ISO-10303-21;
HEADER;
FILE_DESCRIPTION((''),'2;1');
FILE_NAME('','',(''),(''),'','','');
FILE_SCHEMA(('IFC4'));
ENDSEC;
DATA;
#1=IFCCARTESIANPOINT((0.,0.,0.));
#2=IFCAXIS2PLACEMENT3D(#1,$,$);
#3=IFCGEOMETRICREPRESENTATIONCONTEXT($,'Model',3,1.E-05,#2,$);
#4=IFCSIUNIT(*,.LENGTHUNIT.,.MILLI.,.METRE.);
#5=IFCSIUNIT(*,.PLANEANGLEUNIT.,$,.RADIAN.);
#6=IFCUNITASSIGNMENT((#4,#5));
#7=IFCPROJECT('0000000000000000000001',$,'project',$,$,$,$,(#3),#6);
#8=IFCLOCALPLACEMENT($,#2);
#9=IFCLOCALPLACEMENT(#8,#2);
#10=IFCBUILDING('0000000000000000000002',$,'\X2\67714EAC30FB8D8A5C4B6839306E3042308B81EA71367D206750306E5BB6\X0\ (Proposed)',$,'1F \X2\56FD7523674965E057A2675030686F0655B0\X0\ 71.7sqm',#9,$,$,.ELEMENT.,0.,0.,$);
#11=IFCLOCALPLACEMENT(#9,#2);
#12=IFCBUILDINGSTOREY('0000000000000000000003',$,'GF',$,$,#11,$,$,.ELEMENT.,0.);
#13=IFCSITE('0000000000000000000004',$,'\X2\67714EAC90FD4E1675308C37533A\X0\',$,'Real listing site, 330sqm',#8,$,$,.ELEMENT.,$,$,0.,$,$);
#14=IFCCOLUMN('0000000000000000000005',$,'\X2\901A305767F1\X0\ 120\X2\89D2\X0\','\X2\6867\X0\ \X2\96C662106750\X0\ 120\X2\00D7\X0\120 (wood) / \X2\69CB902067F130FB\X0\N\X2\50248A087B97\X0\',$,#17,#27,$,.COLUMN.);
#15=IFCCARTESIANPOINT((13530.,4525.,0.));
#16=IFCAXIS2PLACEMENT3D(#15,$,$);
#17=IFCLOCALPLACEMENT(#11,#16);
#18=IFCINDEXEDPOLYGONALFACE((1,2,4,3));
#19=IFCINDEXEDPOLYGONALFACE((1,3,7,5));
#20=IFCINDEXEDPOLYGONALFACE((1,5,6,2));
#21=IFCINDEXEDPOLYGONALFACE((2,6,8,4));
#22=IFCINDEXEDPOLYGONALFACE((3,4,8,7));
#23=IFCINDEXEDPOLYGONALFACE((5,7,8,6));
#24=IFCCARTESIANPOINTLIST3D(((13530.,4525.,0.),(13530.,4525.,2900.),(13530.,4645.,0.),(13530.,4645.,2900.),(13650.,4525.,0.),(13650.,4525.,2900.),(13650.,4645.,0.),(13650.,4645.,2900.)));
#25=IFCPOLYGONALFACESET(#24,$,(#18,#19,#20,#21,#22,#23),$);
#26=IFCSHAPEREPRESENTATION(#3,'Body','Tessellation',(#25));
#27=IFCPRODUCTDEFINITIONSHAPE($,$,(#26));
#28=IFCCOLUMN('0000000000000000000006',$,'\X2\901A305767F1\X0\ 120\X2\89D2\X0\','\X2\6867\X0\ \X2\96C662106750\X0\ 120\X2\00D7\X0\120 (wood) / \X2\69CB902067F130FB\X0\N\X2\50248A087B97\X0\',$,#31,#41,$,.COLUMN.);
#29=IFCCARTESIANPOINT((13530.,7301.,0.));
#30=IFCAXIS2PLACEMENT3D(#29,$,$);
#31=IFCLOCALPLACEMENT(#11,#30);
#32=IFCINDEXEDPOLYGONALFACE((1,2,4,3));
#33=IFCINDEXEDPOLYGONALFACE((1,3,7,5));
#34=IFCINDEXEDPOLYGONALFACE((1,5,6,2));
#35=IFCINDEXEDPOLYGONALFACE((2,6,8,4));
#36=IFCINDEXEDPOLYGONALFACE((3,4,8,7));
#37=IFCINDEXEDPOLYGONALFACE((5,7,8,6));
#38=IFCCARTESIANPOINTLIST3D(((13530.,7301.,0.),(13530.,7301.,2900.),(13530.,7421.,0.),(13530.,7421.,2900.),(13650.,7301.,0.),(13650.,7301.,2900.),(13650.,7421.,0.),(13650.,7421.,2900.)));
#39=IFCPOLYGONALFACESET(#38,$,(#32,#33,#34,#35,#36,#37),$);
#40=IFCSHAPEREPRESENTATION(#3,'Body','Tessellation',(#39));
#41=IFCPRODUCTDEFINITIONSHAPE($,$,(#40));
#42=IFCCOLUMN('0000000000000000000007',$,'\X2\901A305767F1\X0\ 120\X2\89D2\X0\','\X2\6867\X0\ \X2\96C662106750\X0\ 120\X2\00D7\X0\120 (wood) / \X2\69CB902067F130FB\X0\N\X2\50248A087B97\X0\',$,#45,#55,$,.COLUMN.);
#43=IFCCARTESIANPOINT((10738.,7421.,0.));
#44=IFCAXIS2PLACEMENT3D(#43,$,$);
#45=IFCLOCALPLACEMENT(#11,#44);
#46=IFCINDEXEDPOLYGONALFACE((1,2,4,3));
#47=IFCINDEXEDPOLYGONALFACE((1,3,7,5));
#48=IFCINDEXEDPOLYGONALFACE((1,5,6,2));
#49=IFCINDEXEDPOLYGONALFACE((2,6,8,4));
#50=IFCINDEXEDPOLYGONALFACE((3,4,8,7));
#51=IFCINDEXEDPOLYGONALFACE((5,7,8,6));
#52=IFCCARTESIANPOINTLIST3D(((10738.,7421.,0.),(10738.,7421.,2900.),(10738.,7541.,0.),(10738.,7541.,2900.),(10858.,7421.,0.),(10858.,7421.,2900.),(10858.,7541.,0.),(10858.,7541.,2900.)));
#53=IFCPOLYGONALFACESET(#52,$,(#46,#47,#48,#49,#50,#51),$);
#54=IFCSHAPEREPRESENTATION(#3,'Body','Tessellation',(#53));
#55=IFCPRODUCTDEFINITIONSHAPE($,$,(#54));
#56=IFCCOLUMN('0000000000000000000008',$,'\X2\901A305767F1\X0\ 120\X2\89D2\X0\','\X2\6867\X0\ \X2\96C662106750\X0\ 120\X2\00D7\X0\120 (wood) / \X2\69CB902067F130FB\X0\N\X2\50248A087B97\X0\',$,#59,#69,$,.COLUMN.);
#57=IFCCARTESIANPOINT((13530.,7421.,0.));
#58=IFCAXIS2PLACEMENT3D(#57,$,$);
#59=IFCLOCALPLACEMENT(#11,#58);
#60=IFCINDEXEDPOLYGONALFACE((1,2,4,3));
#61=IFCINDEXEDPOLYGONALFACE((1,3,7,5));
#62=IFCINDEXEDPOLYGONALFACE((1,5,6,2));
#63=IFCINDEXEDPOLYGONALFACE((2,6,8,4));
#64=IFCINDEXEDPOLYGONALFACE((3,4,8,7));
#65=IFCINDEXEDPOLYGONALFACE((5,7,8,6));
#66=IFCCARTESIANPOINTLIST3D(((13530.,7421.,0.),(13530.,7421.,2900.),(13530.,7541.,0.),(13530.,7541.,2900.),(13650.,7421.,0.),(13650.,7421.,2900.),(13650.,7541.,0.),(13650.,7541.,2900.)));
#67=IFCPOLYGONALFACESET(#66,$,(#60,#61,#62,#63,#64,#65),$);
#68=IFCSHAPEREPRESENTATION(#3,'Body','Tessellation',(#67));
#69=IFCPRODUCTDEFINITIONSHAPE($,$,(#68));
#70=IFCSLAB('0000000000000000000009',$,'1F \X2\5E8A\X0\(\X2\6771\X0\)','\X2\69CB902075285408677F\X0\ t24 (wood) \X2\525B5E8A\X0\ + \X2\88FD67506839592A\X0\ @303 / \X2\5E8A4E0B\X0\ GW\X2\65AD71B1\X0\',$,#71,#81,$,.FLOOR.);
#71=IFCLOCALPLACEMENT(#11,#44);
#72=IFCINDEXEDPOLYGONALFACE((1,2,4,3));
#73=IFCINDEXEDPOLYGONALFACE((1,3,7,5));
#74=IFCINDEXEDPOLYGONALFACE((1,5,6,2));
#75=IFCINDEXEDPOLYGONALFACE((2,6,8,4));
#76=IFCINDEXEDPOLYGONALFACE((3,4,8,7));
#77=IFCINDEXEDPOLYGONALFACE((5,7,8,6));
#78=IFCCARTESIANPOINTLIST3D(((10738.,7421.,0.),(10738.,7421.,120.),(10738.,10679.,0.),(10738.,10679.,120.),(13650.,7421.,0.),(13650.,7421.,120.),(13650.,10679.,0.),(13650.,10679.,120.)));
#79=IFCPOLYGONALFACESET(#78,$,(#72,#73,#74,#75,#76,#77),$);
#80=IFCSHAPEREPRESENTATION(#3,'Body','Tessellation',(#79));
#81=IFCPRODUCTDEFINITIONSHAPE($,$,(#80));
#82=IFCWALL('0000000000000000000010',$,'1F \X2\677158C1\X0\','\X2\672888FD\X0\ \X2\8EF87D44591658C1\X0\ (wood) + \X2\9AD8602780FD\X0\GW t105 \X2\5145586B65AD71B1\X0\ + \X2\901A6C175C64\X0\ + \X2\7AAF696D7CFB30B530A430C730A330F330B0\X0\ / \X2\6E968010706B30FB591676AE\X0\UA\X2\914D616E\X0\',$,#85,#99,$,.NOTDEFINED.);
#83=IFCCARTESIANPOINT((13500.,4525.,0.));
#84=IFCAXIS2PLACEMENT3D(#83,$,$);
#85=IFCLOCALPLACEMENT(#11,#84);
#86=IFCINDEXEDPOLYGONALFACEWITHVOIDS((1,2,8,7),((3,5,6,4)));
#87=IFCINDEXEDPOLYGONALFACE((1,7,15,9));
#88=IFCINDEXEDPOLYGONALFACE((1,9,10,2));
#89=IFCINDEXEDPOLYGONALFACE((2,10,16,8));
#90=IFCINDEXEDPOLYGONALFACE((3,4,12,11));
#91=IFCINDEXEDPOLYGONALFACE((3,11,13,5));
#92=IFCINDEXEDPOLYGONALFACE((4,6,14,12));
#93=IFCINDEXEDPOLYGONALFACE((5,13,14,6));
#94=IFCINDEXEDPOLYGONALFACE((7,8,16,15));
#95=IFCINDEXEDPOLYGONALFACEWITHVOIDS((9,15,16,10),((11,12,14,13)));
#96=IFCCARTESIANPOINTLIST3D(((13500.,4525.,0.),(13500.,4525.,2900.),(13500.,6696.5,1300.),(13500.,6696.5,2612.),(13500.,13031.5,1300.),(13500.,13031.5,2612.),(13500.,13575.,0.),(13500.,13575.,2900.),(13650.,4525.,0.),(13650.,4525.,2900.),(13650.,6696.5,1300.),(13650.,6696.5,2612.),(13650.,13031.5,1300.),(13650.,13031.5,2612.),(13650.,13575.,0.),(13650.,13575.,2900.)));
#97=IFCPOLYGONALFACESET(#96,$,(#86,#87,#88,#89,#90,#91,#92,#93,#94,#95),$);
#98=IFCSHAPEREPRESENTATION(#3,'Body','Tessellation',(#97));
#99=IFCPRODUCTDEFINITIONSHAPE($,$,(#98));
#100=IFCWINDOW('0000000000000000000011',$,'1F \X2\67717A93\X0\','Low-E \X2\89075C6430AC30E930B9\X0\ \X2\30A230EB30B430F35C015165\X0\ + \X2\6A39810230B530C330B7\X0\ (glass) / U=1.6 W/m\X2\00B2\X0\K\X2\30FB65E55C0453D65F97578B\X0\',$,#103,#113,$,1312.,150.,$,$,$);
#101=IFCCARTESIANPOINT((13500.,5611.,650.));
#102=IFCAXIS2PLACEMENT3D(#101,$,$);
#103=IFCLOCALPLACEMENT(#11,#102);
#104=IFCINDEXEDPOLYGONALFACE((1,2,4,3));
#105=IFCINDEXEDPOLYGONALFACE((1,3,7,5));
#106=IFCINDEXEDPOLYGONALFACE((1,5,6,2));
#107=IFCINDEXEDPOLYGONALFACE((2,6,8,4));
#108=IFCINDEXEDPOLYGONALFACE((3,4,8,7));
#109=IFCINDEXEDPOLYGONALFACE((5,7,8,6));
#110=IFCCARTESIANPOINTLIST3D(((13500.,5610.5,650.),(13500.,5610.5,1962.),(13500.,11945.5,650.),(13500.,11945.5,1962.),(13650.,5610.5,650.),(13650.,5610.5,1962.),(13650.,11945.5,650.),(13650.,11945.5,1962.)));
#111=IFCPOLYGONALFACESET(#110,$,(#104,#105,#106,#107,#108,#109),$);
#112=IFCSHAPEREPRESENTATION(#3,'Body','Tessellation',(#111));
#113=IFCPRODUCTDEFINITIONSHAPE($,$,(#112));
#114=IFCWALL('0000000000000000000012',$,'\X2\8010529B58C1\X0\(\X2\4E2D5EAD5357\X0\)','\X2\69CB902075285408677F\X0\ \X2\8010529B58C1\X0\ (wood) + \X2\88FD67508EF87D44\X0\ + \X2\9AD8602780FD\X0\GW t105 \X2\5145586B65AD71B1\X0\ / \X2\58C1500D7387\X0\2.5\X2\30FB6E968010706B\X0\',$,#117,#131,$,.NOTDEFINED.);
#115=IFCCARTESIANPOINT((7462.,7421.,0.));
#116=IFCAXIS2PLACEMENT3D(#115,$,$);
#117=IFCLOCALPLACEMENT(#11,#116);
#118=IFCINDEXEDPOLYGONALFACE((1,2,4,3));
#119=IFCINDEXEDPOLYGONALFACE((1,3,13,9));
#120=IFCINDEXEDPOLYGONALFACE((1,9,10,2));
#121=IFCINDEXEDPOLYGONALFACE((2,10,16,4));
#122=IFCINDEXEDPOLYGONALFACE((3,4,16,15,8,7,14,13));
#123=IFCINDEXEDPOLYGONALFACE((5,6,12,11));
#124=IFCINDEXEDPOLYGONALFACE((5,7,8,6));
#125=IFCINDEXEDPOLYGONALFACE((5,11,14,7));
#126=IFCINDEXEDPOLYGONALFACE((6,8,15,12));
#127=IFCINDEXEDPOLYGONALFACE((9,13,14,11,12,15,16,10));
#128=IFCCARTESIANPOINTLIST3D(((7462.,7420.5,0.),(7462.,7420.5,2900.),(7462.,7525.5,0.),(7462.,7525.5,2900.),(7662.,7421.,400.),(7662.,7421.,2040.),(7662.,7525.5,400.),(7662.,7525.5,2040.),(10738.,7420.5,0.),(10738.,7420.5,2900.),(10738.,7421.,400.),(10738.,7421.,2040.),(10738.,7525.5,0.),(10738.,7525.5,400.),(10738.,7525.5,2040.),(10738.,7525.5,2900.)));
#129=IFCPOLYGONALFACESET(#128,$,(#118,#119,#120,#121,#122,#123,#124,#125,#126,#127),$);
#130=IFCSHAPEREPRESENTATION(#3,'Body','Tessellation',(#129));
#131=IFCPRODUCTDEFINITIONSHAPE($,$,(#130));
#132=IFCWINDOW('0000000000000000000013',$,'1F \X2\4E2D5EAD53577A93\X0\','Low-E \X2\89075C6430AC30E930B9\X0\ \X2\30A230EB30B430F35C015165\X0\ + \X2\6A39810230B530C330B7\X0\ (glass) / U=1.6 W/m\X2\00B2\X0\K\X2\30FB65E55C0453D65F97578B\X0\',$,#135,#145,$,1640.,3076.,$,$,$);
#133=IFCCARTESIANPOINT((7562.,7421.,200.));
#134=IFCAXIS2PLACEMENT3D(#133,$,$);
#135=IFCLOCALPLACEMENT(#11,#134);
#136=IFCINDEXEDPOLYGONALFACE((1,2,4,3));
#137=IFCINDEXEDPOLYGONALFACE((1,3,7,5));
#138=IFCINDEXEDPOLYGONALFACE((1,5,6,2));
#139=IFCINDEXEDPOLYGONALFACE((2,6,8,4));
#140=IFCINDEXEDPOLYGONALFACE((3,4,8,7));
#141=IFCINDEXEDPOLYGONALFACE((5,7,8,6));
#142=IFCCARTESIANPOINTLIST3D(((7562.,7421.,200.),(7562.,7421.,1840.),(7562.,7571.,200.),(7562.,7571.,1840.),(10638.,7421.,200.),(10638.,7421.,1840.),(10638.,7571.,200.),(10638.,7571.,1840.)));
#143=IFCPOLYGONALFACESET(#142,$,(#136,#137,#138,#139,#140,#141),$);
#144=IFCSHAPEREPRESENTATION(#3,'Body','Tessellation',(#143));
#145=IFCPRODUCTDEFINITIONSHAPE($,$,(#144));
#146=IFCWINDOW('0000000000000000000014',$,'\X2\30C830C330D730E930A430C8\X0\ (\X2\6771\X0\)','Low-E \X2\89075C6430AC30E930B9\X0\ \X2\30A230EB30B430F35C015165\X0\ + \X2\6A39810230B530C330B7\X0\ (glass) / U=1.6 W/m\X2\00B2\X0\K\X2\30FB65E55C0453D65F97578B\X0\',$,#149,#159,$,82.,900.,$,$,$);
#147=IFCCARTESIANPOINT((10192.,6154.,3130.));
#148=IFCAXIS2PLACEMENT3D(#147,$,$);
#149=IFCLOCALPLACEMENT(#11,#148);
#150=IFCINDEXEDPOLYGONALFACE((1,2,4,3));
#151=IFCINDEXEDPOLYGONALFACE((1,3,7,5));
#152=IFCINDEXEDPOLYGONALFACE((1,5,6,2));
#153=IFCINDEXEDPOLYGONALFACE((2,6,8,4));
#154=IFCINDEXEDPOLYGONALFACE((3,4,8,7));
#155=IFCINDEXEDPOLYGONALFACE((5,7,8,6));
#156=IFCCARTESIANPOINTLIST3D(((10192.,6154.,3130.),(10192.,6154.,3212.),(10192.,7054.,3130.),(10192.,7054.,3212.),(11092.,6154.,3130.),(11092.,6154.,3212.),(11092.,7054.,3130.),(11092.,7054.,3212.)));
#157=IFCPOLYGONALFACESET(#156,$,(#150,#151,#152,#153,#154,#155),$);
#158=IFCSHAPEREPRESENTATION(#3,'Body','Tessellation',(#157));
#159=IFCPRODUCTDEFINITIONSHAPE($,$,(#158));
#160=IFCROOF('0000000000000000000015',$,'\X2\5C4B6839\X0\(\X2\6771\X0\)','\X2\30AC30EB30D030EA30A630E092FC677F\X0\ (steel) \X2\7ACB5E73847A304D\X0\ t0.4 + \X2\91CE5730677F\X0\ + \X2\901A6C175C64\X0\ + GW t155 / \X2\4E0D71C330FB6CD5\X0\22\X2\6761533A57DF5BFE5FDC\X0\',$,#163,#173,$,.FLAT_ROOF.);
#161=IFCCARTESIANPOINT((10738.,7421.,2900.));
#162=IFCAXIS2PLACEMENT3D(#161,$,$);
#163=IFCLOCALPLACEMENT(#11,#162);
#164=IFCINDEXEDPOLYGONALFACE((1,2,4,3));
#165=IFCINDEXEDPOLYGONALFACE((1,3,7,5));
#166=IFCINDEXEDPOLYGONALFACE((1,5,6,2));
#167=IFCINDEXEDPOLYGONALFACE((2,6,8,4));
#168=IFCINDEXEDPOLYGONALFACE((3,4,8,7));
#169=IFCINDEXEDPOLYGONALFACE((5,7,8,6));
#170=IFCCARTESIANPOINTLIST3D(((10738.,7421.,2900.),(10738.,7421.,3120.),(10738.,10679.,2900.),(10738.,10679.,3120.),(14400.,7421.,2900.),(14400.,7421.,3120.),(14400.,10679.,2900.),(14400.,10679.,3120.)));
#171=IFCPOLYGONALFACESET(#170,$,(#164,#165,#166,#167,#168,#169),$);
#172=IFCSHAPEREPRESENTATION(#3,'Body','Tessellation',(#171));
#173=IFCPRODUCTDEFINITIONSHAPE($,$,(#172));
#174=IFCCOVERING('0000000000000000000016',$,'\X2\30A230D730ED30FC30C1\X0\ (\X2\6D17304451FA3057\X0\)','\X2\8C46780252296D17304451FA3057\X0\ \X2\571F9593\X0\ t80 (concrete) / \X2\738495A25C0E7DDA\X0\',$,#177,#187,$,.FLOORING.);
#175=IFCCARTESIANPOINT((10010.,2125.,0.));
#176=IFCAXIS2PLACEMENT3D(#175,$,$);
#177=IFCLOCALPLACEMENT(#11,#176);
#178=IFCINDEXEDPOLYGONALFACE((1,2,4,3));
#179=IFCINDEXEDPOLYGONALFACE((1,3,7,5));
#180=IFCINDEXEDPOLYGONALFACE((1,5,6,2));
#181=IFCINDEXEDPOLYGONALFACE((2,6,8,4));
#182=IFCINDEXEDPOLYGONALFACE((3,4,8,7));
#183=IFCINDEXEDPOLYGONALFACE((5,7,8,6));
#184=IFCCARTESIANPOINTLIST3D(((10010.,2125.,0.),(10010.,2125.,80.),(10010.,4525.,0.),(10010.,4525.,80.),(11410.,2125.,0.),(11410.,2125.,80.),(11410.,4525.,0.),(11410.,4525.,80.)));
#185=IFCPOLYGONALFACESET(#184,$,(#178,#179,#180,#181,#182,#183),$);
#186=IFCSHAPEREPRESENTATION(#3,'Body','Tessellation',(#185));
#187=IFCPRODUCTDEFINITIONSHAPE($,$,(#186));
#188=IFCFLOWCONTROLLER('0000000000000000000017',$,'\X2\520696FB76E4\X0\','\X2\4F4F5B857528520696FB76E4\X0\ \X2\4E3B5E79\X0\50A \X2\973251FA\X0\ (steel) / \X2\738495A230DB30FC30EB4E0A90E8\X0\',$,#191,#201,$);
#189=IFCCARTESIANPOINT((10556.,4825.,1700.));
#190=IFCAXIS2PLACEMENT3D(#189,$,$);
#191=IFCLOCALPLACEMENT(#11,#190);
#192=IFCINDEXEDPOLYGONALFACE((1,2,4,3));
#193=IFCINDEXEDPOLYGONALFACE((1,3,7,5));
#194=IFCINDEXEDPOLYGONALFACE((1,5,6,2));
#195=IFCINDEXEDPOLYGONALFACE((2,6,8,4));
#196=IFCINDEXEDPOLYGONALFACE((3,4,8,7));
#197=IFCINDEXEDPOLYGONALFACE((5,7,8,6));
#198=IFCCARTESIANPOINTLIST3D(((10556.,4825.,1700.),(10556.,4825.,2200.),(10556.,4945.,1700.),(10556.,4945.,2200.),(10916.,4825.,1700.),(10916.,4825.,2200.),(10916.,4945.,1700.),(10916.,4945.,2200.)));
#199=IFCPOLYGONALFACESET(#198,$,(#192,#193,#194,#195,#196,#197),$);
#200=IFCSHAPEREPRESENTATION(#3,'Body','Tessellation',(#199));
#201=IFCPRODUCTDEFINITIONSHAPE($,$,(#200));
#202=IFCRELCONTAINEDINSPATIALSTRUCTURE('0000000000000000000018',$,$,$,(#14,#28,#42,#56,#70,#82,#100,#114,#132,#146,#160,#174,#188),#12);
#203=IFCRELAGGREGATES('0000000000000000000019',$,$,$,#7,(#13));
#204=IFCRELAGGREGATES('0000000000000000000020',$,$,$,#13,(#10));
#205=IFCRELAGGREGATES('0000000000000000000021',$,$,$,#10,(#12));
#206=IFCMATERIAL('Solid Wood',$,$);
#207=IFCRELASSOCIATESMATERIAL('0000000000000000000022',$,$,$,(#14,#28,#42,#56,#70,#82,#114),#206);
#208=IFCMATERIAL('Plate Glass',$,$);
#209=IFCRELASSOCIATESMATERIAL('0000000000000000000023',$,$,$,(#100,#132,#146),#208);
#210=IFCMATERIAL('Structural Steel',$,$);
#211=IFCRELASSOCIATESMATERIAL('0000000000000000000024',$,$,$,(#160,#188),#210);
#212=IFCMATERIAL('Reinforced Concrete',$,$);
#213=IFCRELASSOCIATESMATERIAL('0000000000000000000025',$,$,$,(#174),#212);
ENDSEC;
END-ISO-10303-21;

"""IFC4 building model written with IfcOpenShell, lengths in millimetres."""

from ifc_helpers import new_model, si_unit, frame, frame_2d, origin, place, context, project, spatial, rectangle, extrude, material, element, fill, save


model = new_model("IFC4")

# Units and contexts
model_context = context("Model", 3, precision=1e-05, world=origin())
ifc_project = project(units=[si_unit("LENGTHUNIT", "METRE", prefix="MILLI"), si_unit("PLANEANGLEUNIT", "RADIAN")], contexts=[model_context])

# Site, building, storey
site_placement = place(None, origin())
site = spatial("IfcSite", under=ifc_project, at=site_placement, Name="東京都世田谷区", ObjectType="Real listing site, 330sqm", CompositionType="ELEMENT", RefElevation=0.0)
building_placement = place(site_placement, origin())
building = spatial("IfcBuilding", under=site, at=building_placement, Name="東京・越屋根のある自然素材の家 (Proposed)", ObjectType="1F 国産杉无垢材と漆喰 71.7sqm", CompositionType="ELEMENT", ElevationOfRefHeight=0.0, ElevationOfTerrain=0.0)
storey_placement = place(building_placement, origin())
storey = spatial("IfcBuildingStorey", under=building, at=storey_placement, Name="GF", CompositionType="ELEMENT", Elevation=0.0)

# Columns
ifc_material_1 = material(Name="Solid Wood")
column_1_placement = place(storey_placement, frame((13530.0, 4525.0, 0.0)))
element("IfcColumn", 1, at=column_1_placement, inside=storey, material=ifc_material_1, Name="通し柱 120角", Description="桧 集成材 120×120 (wood) / 構造柱・N値計算", PredefinedType="COLUMN", context=model_context, shape_type="SweptSolid", body=[
    extrude(rectangle(XDim=120.0, YDim=120.0, at=frame_2d((60.0, 60.0))), frame((13530.0, 4525.0, 0.0)), (0.0, 0.0, 1.0), 2900.0),
])
column_2_placement = place(storey_placement, frame((13530.0, 7301.0, 0.0)))
element("IfcColumn", 2, at=column_2_placement, inside=storey, material=ifc_material_1, Name="通し柱 120角", Description="桧 集成材 120×120 (wood) / 構造柱・N値計算", PredefinedType="COLUMN", context=model_context, shape_type="SweptSolid", body=[
    extrude(rectangle(XDim=120.0, YDim=120.0, at=frame_2d((60.0, 60.0))), frame((13530.0, 7301.0, 0.0)), (0.0, 0.0, 1.0), 2900.0),
])
column_3_placement = place(storey_placement, frame((10738.0, 7421.0, 0.0)))
element("IfcColumn", 3, at=column_3_placement, inside=storey, material=ifc_material_1, Name="通し柱 120角", Description="桧 集成材 120×120 (wood) / 構造柱・N値計算", PredefinedType="COLUMN", context=model_context, shape_type="SweptSolid", body=[
    extrude(rectangle(XDim=120.0, YDim=120.0, at=frame_2d((60.0, 60.0))), frame((10738.0, 7421.0, 0.0)), (0.0, 0.0, 1.0), 2900.0),
])
column_4_placement = place(storey_placement, frame((13530.0, 7421.0, 0.0)))
element("IfcColumn", 4, at=column_4_placement, inside=storey, material=ifc_material_1, Name="通し柱 120角", Description="桧 集成材 120×120 (wood) / 構造柱・N値計算", PredefinedType="COLUMN", context=model_context, shape_type="SweptSolid", body=[
    extrude(rectangle(XDim=120.0, YDim=120.0, at=frame_2d((60.0, 60.0))), frame((13530.0, 7421.0, 0.0)), (0.0, 0.0, 1.0), 2900.0),
])

# Slab
slab_placement = place(storey_placement, frame((10738.0, 7421.0, 0.0)))
element("IfcSlab", 5, at=slab_placement, inside=storey, material=ifc_material_1, Name="1F 床(東)", Description="構造用合板 t24 (wood) 剛床 + 製材根太 @303 / 床下 GW断熱", PredefinedType="FLOOR", context=model_context, shape_type="SweptSolid", body=[
    extrude(rectangle(XDim=2912.0, YDim=3258.0, at=frame_2d((1456.0, 1629.0))), frame((10738.0, 7421.0, 0.0)), (0.0, 0.0, 1.0), 120.0),
])

# Walls, openings, windows
wall_1_placement = place(storey_placement, frame((13500.0, 4525.0, 0.0)))
wall_1 = element("IfcWall", 6, at=wall_1_placement, inside=storey, material=ifc_material_1, Name="1F 東壁", Description="木製 軸組外壁 (wood) + 高性能GW t105 充填断熱 + 通気層 + 窯業系サイディング / 準耐火・外皮UA配慮", PredefinedType="NOTDEFINED", context=model_context, shape_type="SweptSolid", body=[
    extrude(rectangle(XDim=150.0, YDim=9050.0, at=frame_2d((75.0, 4525.0))), frame((13500.0, 4525.0, 0.0)), (0.0, 0.0, 1.0), 2900.0),
])
opening_1_placement = place(storey_placement, frame((13500.0, 5611.0, 650.0)))
opening_1 = element("IfcOpeningElement", 7, at=opening_1_placement, cuts=wall_1, PredefinedType="NOTDEFINED", context=model_context, shape_type="SweptSolid", body=[
    extrude(rectangle(XDim=150.0, YDim=6335.0, at=frame_2d((75.0, 3167.0))), frame((13500.0, 5611.0, 650.0)), (0.0, 0.0, 1.0), 1312.0),
])
ifc_material_2 = material(Name="Plate Glass")
window_1_placement = place(storey_placement, frame((13500.0, 5611.0, 650.0)))
window_1 = element("IfcWindow", 8, at=window_1_placement, inside=storey, material=ifc_material_2, Name="1F 東窓", Description="Low-E 複層ガラス アルゴン封入 + 樹脂サッシ (glass) / U=1.6 W/m²K・日射取得型", OverallHeight=1312.0, OverallWidth=150.0, context=model_context, shape_type="SweptSolid", body=[
    extrude(rectangle(XDim=150.0, YDim=6335.0, at=frame_2d((75.0, 3167.0))), frame((13500.0, 5611.0, 650.0)), (0.0, 0.0, 1.0), 1312.0),
])
fill(opening_1, window_1)
wall_2_placement = place(storey_placement, frame((7462.0, 7421.0, 0.0)))
wall_2 = element("IfcWall", 9, at=wall_2_placement, inside=storey, material=ifc_material_1, Name="耐力壁(中庭南)", Description="構造用合板 耐力壁 (wood) + 製材軸組 + 高性能GW t105 充填断熱 / 壁倍率2.5・準耐火", PredefinedType="NOTDEFINED", context=model_context, shape_type="SweptSolid", body=[
    extrude(rectangle(XDim=3276.0, YDim=105.0, at=frame_2d((1638.0, 52.0))), frame((7462.0, 7421.0, 0.0)), (0.0, 0.0, 1.0), 2900.0),
])
opening_2_placement = place(storey_placement, frame((7562.0, 7421.0, 200.0)))
opening_2 = element("IfcOpeningElement", 10, at=opening_2_placement, cuts=wall_2, PredefinedType="NOTDEFINED", context=model_context, shape_type="SweptSolid", body=[
    extrude(rectangle(XDim=3076.0, YDim=150.0, at=frame_2d((1538.0, 75.0))), frame((7562.0, 7421.0, 200.0)), (0.0, 0.0, 1.0), 1640.0),
])
window_2_placement = place(storey_placement, frame((7562.0, 7421.0, 200.0)))
window_2 = element("IfcWindow", 11, at=window_2_placement, inside=storey, material=ifc_material_2, Name="1F 中庭南窓", Description="Low-E 複層ガラス アルゴン封入 + 樹脂サッシ (glass) / U=1.6 W/m²K・日射取得型", OverallHeight=1640.0, OverallWidth=3076.0, context=model_context, shape_type="SweptSolid", body=[
    extrude(rectangle(XDim=3076.0, YDim=150.0, at=frame_2d((1538.0, 75.0))), frame((7562.0, 7421.0, 200.0)), (0.0, 0.0, 1.0), 1640.0),
])
fill(opening_2, window_2)

# Window
window_3_placement = place(storey_placement, frame((10192.0, 6154.0, 3130.0)))
element("IfcWindow", 12, at=window_3_placement, inside=storey, material=ifc_material_2, Name="トップライト (東)", Description="Low-E 複層ガラス アルゴン封入 + 樹脂サッシ (glass) / U=1.6 W/m²K・日射取得型", OverallHeight=82.0, OverallWidth=900.0, context=model_context, shape_type="SweptSolid", body=[
    extrude(rectangle(XDim=900.0, YDim=900.0, at=frame_2d((450.0, 450.0))), frame((10192.0, 6154.0, 3130.0)), (0.0, 0.0, 1.0), 82.0),
])

# Roof
ifc_material_3 = material(Name="Structural Steel")
roof_placement = place(storey_placement, frame((10738.0, 7421.0, 2900.0)))
element("IfcRoof", 13, at=roof_placement, inside=storey, material=ifc_material_3, Name="屋根(東)", Description="ガルバリウム鋼板 (steel) 立平葺き t0.4 + 野地板 + 通気層 + GW t155 / 不燃・法22条区域対応", PredefinedType="FLAT_ROOF", context=model_context, shape_type="SweptSolid", body=[
    extrude(rectangle(XDim=3662.0, YDim=3258.0, at=frame_2d((1831.0, 1629.0))), frame((10738.0, 7421.0, 2900.0)), (0.0, 0.0, 1.0), 220.0),
])

# Covering
ifc_material_4 = material(Name="Reinforced Concrete")
covering_placement = place(storey_placement, frame((10010.0, 2125.0, 0.0)))
element("IfcCovering", 14, at=covering_placement, inside=storey, material=ifc_material_4, Name="アプローチ (洗い出し)", Description="豆砂利洗い出し 土間 t80 (concrete) / 玄関導線", PredefinedType="FLOORING", context=model_context, shape_type="SweptSolid", body=[
    extrude(rectangle(XDim=1400.0, YDim=2400.0, at=frame_2d((700.0, 1200.0))), frame((10010.0, 2125.0, 0.0)), (0.0, 0.0, 1.0), 80.0),
])

# Flow controller
flow_controller_placement = place(storey_placement, frame((10556.0, 4825.0, 1700.0)))
element("IfcFlowController", 15, at=flow_controller_placement, inside=storey, material=ifc_material_3, Name="分電盤", Description="住宅用分電盤 主幹50A 露出 (steel) / 玄関ホール上部", context=model_context, shape_type="SweptSolid", body=[
    extrude(rectangle(XDim=360.0, YDim=120.0, at=frame_2d((180.0, 60.0))), frame((10556.0, 4825.0, 1700.0)), (0.0, 0.0, 1.0), 500.0),
])

save(model, "model.ifc")
